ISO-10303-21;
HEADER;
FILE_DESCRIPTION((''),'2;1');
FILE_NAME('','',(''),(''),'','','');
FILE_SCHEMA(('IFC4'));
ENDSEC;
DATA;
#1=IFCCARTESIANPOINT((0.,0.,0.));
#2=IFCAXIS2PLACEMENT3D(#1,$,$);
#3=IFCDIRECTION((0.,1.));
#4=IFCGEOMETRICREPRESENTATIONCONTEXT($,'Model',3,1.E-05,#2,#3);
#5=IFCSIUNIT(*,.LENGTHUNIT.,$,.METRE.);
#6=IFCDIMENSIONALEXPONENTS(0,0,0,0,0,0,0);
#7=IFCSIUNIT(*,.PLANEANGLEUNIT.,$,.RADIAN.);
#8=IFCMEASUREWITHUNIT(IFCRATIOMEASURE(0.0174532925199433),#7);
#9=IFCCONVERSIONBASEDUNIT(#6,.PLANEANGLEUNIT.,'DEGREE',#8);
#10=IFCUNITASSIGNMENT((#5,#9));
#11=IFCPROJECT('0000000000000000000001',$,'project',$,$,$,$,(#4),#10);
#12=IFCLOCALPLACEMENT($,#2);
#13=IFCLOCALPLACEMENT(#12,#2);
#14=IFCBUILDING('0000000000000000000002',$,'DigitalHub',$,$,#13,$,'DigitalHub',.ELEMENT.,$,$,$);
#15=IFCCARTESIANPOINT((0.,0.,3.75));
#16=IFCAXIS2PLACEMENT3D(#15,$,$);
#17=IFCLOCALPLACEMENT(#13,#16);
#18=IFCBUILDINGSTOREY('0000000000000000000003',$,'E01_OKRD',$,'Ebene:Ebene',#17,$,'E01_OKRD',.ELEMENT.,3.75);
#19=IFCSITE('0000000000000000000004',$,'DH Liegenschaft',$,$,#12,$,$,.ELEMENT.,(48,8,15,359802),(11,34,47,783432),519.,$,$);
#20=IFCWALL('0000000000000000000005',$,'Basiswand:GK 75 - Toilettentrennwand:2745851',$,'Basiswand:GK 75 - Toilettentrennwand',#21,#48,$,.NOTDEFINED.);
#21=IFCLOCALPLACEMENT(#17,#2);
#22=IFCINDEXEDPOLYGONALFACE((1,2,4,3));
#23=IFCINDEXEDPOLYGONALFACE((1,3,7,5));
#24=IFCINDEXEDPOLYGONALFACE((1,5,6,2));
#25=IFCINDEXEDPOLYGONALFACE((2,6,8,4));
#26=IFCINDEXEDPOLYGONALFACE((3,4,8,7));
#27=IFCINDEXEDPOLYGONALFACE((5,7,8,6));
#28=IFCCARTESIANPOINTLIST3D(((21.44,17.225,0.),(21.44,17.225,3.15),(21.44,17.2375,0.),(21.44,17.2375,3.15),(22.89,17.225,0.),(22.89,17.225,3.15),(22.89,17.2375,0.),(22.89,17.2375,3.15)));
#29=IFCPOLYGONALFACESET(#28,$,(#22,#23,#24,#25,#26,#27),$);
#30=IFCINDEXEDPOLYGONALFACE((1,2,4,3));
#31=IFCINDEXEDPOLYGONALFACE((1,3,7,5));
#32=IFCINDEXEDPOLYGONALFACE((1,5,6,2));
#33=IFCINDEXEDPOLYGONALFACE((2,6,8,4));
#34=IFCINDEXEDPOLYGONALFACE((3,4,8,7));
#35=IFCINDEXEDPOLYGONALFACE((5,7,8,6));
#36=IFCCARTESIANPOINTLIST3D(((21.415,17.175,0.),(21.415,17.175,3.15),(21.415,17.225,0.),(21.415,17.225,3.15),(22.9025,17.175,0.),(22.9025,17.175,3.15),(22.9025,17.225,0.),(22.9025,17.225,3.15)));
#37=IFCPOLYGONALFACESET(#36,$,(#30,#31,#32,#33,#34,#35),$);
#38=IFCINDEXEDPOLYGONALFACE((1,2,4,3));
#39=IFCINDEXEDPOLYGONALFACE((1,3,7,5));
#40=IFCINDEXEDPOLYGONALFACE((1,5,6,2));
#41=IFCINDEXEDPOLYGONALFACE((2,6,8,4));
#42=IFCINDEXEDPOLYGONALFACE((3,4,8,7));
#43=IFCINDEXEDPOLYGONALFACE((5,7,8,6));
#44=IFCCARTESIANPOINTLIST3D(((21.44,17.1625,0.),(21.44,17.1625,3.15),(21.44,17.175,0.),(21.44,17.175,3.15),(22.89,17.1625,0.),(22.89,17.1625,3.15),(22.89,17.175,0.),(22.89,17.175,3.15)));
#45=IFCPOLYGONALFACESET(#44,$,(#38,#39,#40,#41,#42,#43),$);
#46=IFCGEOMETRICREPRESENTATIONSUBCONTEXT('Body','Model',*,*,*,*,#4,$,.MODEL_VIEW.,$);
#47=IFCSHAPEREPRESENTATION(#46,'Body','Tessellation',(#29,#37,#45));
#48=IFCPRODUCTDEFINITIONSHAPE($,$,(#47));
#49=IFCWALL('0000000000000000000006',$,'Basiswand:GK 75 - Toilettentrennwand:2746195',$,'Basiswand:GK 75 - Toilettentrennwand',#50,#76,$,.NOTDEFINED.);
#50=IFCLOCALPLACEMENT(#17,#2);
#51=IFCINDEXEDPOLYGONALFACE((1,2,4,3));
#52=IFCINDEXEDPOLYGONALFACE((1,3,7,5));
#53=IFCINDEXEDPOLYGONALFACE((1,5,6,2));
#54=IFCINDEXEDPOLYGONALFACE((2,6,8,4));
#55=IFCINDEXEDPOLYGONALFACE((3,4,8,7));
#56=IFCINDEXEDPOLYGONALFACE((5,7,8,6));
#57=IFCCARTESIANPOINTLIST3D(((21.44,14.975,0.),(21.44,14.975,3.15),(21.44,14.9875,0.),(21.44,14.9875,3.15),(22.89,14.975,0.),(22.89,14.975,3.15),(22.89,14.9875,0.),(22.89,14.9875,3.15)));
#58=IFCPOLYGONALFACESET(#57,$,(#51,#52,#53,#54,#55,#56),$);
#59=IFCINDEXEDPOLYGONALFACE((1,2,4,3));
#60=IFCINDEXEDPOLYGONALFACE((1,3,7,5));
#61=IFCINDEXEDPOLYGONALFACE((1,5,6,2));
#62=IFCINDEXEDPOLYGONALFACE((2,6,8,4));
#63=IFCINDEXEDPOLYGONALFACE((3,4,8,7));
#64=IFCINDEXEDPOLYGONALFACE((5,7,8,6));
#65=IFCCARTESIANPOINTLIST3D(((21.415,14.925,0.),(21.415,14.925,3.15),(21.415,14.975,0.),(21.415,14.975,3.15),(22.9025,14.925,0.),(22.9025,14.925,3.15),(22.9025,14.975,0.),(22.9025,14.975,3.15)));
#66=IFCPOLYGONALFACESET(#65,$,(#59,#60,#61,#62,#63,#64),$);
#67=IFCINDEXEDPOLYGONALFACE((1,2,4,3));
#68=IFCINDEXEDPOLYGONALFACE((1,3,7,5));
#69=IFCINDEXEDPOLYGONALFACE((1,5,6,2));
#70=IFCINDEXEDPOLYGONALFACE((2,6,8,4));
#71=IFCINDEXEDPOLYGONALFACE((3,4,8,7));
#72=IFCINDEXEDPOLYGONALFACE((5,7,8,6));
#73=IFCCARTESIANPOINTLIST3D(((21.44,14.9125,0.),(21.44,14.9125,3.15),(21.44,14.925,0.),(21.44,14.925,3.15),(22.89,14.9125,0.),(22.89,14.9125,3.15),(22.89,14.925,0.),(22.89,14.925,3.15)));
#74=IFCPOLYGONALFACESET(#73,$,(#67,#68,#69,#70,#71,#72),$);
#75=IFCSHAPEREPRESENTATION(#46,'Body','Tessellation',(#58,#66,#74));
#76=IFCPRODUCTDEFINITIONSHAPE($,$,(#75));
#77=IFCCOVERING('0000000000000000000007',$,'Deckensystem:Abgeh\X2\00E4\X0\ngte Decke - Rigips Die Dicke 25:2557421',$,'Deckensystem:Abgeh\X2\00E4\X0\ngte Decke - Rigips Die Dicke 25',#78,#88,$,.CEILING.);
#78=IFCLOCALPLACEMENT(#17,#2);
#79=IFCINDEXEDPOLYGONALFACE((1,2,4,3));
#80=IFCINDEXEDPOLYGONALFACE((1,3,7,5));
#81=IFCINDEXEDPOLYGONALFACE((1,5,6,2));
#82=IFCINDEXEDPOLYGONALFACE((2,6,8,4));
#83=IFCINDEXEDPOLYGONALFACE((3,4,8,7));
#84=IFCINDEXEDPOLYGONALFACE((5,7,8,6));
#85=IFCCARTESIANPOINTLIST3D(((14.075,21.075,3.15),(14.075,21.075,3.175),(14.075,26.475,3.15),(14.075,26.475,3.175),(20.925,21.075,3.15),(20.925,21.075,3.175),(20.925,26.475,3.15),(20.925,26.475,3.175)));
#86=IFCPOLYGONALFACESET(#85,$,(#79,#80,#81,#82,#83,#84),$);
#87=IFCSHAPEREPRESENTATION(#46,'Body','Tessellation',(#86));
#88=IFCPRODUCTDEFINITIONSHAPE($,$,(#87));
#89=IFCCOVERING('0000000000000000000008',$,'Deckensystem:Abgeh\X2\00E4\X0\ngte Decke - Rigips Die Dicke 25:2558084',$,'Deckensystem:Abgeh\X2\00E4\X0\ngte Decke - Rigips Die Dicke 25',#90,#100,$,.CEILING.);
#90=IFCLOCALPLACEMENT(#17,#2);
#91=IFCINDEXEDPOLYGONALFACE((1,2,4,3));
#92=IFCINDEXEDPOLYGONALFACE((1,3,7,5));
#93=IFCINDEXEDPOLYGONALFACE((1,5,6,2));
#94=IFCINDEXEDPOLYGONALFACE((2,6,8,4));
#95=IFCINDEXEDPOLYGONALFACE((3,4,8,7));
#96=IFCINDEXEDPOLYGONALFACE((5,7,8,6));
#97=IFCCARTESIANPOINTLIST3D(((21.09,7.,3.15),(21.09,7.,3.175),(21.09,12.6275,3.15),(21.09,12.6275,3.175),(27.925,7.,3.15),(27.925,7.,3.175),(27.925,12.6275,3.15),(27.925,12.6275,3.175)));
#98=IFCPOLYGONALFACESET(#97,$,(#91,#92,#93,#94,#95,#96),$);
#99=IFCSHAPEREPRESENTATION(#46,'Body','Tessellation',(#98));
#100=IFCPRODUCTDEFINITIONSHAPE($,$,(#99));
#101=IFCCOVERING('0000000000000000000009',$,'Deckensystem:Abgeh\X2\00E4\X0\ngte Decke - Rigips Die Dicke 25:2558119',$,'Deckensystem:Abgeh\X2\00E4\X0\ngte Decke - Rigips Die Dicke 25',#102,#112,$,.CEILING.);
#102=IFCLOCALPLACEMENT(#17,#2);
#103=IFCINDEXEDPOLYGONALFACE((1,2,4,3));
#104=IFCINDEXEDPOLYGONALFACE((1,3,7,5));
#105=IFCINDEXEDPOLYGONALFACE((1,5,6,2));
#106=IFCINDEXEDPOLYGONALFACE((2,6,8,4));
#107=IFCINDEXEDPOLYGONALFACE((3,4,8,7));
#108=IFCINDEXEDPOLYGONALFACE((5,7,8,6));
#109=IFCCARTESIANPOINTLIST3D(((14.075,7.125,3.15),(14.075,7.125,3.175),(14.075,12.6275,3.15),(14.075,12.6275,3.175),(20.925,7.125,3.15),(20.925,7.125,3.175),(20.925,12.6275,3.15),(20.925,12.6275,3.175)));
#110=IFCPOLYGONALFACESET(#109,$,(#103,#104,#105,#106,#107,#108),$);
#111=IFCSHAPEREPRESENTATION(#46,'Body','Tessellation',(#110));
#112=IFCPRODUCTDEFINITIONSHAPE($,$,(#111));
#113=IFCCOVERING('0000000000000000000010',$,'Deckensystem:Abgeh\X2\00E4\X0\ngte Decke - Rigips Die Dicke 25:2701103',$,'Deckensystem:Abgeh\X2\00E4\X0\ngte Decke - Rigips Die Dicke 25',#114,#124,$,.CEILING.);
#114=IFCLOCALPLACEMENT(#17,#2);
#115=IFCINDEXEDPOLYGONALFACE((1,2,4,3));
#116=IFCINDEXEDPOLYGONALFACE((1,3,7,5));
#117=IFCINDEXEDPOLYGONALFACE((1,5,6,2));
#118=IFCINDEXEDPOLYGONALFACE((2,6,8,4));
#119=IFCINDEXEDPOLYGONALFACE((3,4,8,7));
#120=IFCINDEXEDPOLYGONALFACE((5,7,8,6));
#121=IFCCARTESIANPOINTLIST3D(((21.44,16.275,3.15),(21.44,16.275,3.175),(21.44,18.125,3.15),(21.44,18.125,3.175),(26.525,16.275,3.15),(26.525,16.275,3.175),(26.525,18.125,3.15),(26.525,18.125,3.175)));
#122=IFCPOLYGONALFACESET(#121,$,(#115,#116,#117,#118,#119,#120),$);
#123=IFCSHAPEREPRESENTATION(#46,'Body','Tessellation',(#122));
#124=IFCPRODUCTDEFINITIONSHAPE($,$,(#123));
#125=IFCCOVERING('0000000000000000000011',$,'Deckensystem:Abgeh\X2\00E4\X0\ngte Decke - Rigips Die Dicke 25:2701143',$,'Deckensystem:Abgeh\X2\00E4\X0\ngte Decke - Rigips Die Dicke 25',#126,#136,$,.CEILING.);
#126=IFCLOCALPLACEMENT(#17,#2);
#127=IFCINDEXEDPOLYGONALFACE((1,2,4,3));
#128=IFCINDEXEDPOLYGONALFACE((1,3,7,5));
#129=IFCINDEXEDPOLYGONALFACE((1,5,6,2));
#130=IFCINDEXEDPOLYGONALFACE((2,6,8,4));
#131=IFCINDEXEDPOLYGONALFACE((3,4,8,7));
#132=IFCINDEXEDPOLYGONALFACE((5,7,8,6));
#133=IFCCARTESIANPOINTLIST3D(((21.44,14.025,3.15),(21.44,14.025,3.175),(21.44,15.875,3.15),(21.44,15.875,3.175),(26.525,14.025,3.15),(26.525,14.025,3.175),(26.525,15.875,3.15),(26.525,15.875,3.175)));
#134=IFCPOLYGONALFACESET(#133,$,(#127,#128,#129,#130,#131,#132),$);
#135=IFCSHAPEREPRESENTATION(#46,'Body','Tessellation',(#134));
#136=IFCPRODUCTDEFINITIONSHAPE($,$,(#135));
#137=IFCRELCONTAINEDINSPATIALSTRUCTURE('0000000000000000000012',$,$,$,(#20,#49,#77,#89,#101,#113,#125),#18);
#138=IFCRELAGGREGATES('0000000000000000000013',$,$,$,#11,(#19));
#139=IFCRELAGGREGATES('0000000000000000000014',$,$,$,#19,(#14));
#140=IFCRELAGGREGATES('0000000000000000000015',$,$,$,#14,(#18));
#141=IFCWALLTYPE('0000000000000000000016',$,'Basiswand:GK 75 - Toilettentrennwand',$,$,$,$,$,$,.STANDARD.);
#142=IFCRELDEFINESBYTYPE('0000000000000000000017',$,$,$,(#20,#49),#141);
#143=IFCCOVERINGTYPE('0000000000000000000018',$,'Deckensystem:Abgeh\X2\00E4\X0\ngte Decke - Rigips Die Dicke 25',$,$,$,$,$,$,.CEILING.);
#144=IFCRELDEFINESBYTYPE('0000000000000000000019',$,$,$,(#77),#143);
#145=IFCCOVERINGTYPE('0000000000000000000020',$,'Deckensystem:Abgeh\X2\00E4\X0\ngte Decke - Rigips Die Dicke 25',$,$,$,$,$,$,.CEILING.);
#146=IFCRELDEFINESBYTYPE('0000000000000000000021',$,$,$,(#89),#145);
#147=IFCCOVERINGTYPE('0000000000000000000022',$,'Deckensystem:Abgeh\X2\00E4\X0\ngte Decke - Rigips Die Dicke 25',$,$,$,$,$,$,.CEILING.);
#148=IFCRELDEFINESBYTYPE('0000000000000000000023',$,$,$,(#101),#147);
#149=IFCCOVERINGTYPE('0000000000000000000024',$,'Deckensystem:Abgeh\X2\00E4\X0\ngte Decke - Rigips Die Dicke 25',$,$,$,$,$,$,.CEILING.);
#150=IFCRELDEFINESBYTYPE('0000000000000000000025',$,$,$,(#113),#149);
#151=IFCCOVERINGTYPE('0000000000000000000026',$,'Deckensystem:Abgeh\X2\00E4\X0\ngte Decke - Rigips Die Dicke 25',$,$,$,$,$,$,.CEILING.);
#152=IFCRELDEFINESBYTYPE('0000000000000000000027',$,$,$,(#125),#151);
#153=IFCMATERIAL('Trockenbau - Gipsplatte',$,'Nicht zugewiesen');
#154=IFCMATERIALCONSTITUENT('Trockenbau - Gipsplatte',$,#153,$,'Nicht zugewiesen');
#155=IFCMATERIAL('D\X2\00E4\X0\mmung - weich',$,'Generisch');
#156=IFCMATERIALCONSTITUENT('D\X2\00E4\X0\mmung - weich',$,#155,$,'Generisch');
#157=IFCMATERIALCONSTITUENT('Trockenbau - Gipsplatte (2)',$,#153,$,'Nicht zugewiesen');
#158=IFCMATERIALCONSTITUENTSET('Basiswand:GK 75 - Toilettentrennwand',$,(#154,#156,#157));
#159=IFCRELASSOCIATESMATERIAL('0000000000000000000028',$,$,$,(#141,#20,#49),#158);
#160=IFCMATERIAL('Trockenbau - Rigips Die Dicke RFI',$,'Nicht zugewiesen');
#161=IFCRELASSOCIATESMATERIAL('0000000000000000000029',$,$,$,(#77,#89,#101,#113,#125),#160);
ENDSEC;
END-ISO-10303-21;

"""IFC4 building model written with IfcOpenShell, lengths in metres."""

from ifc_helpers import new_model, entity, si_unit, converted_unit, direction, frame, origin, place, context, subcontext, project, spatial, indexed_curve, outline, extrude, material, constituent, constituent_set, type_object, element, save


model = new_model("IFC4")

# Units and contexts
model_context = context("Model", 3, precision=1e-05, world=origin(), true_north=direction((0.0, 1.0)))
body_context = subcontext(model_context, "Body", "Model", "MODEL_VIEW")
ifc_project = project(units=[si_unit("LENGTHUNIT", "METRE"), converted_unit("PLANEANGLEUNIT", "DEGREE", entity("IfcRatioMeasure", 0.0174532925199433), si_unit("PLANEANGLEUNIT", "RADIAN"), dimensions=[0, 0, 0, 0, 0, 0, 0])], contexts=[model_context])

# Site, building, storey
site_placement = place(None, frame((0.0, 0.0, 0.0)))
site = spatial("IfcSite", under=ifc_project, at=site_placement, Name="DH Liegenschaft", CompositionType="ELEMENT", RefLatitude=(48, 8, 15, 359802), RefLongitude=(11, 34, 47, 783432), RefElevation=519.0)
building_placement = place(site_placement, origin())
building = spatial("IfcBuilding", under=site, at=building_placement, Name="DigitalHub", LongName="DigitalHub", CompositionType="ELEMENT")
storey_placement = place(building_placement, frame((0.0, 0.0, 3.75)))
storey = spatial("IfcBuildingStorey", under=building, at=storey_placement, Name="E01_OKRD", ObjectType="Ebene:Ebene", LongName="E01_OKRD", CompositionType="ELEMENT", Elevation=3.75)

# Wall
ifc_material_1 = material(Name="Trockenbau - Gipsplatte", Category="Nicht zugewiesen")
ifc_material_2 = material(Name="Dämmung - weich", Category="Generisch")
ifc_constituent_1 = constituent(ifc_material_1, Name="Trockenbau - Gipsplatte", Category="Nicht zugewiesen")
ifc_constituent_2 = constituent(ifc_material_2, Name="Dämmung - weich", Category="Generisch")
ifc_constituent_3 = constituent(ifc_material_1, Name="Trockenbau - Gipsplatte (2)", Category="Nicht zugewiesen")
ifc_constituent_set_1 = constituent_set(constituents=[ifc_constituent_1, ifc_constituent_2, ifc_constituent_3], Name="Basiswand:GK 75 - Toilettentrennwand")
wall_type_1 = type_object("IfcWallType", Name="Basiswand:GK 75 - Toilettentrennwand", PredefinedType="STANDARD", material=ifc_constituent_set_1)
wall_1_placement = place(storey_placement, frame((21.44, 17.2, 0.0)))
element("IfcWall", 1, at=wall_1_placement, inside=storey, type_object=wall_type_1, material=ifc_constituent_set_1, Name="Basiswand:GK 75 - Toilettentrennwand:2745851", ObjectType="Basiswand:GK 75 - Toilettentrennwand", PredefinedType="NOTDEFINED", context=body_context, shape_type="SweptSolid", body=[
    extrude(outline(indexed_curve([(-0.0063, -0.725), (0.0062, -0.725), (0.0063, 0.725), (-0.0062, 0.725), (-0.0063, -0.725)], self_intersect=False)), frame((0.725, 0.0313, 0.0), z_axis=(0.0, 0.0, 1.0), x_axis=(0.0, -1.0, 0.0)), (0.0, 0.0, 1.0), 3.15),
    extrude(outline(indexed_curve([(-0.7437, -0.025), (0.7437, -0.025), (0.7437, 0.025), (-0.7437, 0.025), (-0.7437, -0.025)], self_intersect=False)), frame((0.7187, 0.0, 0.0)), (0.0, 0.0, 1.0), 3.15),
    extrude(outline(indexed_curve([(-0.0063, -0.725), (0.0062, -0.725), (0.0063, 0.725), (-0.0062, 0.725), (-0.0063, -0.725)], self_intersect=False)), frame((0.725, -0.0312, 0.0), z_axis=(0.0, 0.0, 1.0), x_axis=(0.0, 1.0, 0.0)), (0.0, 0.0, 1.0), 3.15),
])

# Wall
wall_2_placement = place(storey_placement, frame((22.89, 14.95, 0.0), z_axis=(0.0, 0.0, 1.0), x_axis=(-1.0, 0.0, 0.0)))
element("IfcWall", 2, at=wall_2_placement, inside=storey, type_object=wall_type_1, material=ifc_constituent_set_1, Name="Basiswand:GK 75 - Toilettentrennwand:2746195", ObjectType="Basiswand:GK 75 - Toilettentrennwand", PredefinedType="NOTDEFINED", context=body_context, shape_type="SweptSolid", body=[
    extrude(outline(indexed_curve([(-0.0063, -0.725), (0.0062, -0.725), (0.0063, 0.725), (-0.0062, 0.725), (-0.0063, -0.725)], self_intersect=False)), frame((0.725, -0.0312, 0.0), z_axis=(0.0, 0.0, 1.0), x_axis=(0.0, 1.0, 0.0)), (0.0, 0.0, 1.0), 3.15),
    extrude(outline(indexed_curve([(-0.7438, -0.025), (0.7438, -0.025), (0.7438, 0.025), (-0.7438, 0.025), (-0.7438, -0.025)], self_intersect=False)), frame((0.7312, 0.0, 0.0)), (0.0, 0.0, 1.0), 3.15),
    extrude(outline(indexed_curve([(-0.0063, -0.725), (0.0062, -0.725), (0.0063, 0.725), (-0.0062, 0.725), (-0.0063, -0.725)], self_intersect=False)), frame((0.725, 0.0312, 0.0), z_axis=(0.0, 0.0, 1.0), x_axis=(0.0, -1.0, 0.0)), (0.0, 0.0, 1.0), 3.15),
])

# Coverings
ifc_material_3 = material(Name="Trockenbau - Rigips Die Dicke RFI", Category="Nicht zugewiesen")
covering_type_1 = type_object("IfcCoveringType", Name="Deckensystem:Abgehängte Decke - Rigips Die Dicke 25", PredefinedType="CEILING")
covering_1_placement = place(storey_placement, frame((14.075, 21.075, 3.15)))
element("IfcCovering", 3, at=covering_1_placement, inside=storey, type_object=covering_type_1, material=ifc_material_3, Name="Deckensystem:Abgehängte Decke - Rigips Die Dicke 25:2557421", ObjectType="Deckensystem:Abgehängte Decke - Rigips Die Dicke 25", PredefinedType="CEILING", context=body_context, shape_type="SweptSolid", body=[
    extrude(outline(indexed_curve([(-3.425, -2.7), (3.425, -2.7), (3.425, 2.7), (-3.425, 2.7), (-3.425, -2.7)], self_intersect=False)), frame((3.425, 2.7, 0.0), z_axis=(0.0, 0.0, 1.0), x_axis=(-1.0, 0.0, 0.0)), (0.0, 0.0, 1.0), 0.025),
])
covering_type_2 = type_object("IfcCoveringType", Name="Deckensystem:Abgehängte Decke - Rigips Die Dicke 25", PredefinedType="CEILING")
covering_2_placement = place(storey_placement, frame((21.09, 7.0, 3.15)))
element("IfcCovering", 4, at=covering_2_placement, inside=storey, type_object=covering_type_2, material=ifc_material_3, Name="Deckensystem:Abgehängte Decke - Rigips Die Dicke 25:2558084", ObjectType="Deckensystem:Abgehängte Decke - Rigips Die Dicke 25", PredefinedType="CEILING", context=body_context, shape_type="SweptSolid", body=[
    extrude(outline(indexed_curve([(-2.8137, -3.4175), (2.8137, -3.4175), (2.8137, 3.4175), (-2.8137, 3.4175), (-2.8137, -3.4175)], self_intersect=False)), frame((3.4175, 2.8137, 0.0), z_axis=(0.0, 0.0, 1.0), x_axis=(0.0, -1.0, 0.0)), (0.0, 0.0, 1.0), 0.025),
])
covering_type_3 = type_object("IfcCoveringType", Name="Deckensystem:Abgehängte Decke - Rigips Die Dicke 25", PredefinedType="CEILING")
covering_3_placement = place(storey_placement, frame((14.075, 7.125, 3.15)))
element("IfcCovering", 5, at=covering_3_placement, inside=storey, type_object=covering_type_3, material=ifc_material_3, Name="Deckensystem:Abgehängte Decke - Rigips Die Dicke 25:2558119", ObjectType="Deckensystem:Abgehängte Decke - Rigips Die Dicke 25", PredefinedType="CEILING", context=body_context, shape_type="SweptSolid", body=[
    extrude(outline(indexed_curve([(-2.7512, -3.425), (2.7512, -3.425), (2.7512, 3.425), (-2.7512, 3.425), (-2.7512, -3.425)], self_intersect=False)), frame((3.425, 2.7512, 0.0), z_axis=(0.0, 0.0, 1.0), x_axis=(0.0, -1.0, 0.0)), (0.0, 0.0, 1.0), 0.025),
])
covering_type_4 = type_object("IfcCoveringType", Name="Deckensystem:Abgehängte Decke - Rigips Die Dicke 25", PredefinedType="CEILING")
covering_4_placement = place(storey_placement, frame((21.44, 16.275, 3.15)))
element("IfcCovering", 6, at=covering_4_placement, inside=storey, type_object=covering_type_4, material=ifc_material_3, Name="Deckensystem:Abgehängte Decke - Rigips Die Dicke 25:2701103", ObjectType="Deckensystem:Abgehängte Decke - Rigips Die Dicke 25", PredefinedType="CEILING", context=body_context, shape_type="SweptSolid", body=[
    extrude(outline(indexed_curve([(-2.5425, -0.925), (2.5425, -0.925), (2.5425, 0.925), (-2.5425, 0.925), (-2.5425, -0.925)], self_intersect=False)), frame((2.5425, 0.925, 0.0), z_axis=(0.0, 0.0, 1.0), x_axis=(-1.0, 0.0, 0.0)), (0.0, 0.0, 1.0), 0.025),
])
covering_type_5 = type_object("IfcCoveringType", Name="Deckensystem:Abgehängte Decke - Rigips Die Dicke 25", PredefinedType="CEILING")
covering_5_placement = place(storey_placement, frame((21.44, 14.025, 3.15)))
element("IfcCovering", 7, at=covering_5_placement, inside=storey, type_object=covering_type_5, material=ifc_material_3, Name="Deckensystem:Abgehängte Decke - Rigips Die Dicke 25:2701143", ObjectType="Deckensystem:Abgehängte Decke - Rigips Die Dicke 25", PredefinedType="CEILING", context=body_context, shape_type="SweptSolid", body=[
    extrude(outline(indexed_curve([(-2.5425, -0.925), (2.5425, -0.925), (2.5425, 0.925), (-2.5425, 0.925), (-2.5425, -0.925)], self_intersect=False)), frame((2.5425, 0.925, 0.0), z_axis=(0.0, 0.0, 1.0), x_axis=(-1.0, 0.0, 0.0)), (0.0, 0.0, 1.0), 0.025),
])

save(model, "model.ifc")
